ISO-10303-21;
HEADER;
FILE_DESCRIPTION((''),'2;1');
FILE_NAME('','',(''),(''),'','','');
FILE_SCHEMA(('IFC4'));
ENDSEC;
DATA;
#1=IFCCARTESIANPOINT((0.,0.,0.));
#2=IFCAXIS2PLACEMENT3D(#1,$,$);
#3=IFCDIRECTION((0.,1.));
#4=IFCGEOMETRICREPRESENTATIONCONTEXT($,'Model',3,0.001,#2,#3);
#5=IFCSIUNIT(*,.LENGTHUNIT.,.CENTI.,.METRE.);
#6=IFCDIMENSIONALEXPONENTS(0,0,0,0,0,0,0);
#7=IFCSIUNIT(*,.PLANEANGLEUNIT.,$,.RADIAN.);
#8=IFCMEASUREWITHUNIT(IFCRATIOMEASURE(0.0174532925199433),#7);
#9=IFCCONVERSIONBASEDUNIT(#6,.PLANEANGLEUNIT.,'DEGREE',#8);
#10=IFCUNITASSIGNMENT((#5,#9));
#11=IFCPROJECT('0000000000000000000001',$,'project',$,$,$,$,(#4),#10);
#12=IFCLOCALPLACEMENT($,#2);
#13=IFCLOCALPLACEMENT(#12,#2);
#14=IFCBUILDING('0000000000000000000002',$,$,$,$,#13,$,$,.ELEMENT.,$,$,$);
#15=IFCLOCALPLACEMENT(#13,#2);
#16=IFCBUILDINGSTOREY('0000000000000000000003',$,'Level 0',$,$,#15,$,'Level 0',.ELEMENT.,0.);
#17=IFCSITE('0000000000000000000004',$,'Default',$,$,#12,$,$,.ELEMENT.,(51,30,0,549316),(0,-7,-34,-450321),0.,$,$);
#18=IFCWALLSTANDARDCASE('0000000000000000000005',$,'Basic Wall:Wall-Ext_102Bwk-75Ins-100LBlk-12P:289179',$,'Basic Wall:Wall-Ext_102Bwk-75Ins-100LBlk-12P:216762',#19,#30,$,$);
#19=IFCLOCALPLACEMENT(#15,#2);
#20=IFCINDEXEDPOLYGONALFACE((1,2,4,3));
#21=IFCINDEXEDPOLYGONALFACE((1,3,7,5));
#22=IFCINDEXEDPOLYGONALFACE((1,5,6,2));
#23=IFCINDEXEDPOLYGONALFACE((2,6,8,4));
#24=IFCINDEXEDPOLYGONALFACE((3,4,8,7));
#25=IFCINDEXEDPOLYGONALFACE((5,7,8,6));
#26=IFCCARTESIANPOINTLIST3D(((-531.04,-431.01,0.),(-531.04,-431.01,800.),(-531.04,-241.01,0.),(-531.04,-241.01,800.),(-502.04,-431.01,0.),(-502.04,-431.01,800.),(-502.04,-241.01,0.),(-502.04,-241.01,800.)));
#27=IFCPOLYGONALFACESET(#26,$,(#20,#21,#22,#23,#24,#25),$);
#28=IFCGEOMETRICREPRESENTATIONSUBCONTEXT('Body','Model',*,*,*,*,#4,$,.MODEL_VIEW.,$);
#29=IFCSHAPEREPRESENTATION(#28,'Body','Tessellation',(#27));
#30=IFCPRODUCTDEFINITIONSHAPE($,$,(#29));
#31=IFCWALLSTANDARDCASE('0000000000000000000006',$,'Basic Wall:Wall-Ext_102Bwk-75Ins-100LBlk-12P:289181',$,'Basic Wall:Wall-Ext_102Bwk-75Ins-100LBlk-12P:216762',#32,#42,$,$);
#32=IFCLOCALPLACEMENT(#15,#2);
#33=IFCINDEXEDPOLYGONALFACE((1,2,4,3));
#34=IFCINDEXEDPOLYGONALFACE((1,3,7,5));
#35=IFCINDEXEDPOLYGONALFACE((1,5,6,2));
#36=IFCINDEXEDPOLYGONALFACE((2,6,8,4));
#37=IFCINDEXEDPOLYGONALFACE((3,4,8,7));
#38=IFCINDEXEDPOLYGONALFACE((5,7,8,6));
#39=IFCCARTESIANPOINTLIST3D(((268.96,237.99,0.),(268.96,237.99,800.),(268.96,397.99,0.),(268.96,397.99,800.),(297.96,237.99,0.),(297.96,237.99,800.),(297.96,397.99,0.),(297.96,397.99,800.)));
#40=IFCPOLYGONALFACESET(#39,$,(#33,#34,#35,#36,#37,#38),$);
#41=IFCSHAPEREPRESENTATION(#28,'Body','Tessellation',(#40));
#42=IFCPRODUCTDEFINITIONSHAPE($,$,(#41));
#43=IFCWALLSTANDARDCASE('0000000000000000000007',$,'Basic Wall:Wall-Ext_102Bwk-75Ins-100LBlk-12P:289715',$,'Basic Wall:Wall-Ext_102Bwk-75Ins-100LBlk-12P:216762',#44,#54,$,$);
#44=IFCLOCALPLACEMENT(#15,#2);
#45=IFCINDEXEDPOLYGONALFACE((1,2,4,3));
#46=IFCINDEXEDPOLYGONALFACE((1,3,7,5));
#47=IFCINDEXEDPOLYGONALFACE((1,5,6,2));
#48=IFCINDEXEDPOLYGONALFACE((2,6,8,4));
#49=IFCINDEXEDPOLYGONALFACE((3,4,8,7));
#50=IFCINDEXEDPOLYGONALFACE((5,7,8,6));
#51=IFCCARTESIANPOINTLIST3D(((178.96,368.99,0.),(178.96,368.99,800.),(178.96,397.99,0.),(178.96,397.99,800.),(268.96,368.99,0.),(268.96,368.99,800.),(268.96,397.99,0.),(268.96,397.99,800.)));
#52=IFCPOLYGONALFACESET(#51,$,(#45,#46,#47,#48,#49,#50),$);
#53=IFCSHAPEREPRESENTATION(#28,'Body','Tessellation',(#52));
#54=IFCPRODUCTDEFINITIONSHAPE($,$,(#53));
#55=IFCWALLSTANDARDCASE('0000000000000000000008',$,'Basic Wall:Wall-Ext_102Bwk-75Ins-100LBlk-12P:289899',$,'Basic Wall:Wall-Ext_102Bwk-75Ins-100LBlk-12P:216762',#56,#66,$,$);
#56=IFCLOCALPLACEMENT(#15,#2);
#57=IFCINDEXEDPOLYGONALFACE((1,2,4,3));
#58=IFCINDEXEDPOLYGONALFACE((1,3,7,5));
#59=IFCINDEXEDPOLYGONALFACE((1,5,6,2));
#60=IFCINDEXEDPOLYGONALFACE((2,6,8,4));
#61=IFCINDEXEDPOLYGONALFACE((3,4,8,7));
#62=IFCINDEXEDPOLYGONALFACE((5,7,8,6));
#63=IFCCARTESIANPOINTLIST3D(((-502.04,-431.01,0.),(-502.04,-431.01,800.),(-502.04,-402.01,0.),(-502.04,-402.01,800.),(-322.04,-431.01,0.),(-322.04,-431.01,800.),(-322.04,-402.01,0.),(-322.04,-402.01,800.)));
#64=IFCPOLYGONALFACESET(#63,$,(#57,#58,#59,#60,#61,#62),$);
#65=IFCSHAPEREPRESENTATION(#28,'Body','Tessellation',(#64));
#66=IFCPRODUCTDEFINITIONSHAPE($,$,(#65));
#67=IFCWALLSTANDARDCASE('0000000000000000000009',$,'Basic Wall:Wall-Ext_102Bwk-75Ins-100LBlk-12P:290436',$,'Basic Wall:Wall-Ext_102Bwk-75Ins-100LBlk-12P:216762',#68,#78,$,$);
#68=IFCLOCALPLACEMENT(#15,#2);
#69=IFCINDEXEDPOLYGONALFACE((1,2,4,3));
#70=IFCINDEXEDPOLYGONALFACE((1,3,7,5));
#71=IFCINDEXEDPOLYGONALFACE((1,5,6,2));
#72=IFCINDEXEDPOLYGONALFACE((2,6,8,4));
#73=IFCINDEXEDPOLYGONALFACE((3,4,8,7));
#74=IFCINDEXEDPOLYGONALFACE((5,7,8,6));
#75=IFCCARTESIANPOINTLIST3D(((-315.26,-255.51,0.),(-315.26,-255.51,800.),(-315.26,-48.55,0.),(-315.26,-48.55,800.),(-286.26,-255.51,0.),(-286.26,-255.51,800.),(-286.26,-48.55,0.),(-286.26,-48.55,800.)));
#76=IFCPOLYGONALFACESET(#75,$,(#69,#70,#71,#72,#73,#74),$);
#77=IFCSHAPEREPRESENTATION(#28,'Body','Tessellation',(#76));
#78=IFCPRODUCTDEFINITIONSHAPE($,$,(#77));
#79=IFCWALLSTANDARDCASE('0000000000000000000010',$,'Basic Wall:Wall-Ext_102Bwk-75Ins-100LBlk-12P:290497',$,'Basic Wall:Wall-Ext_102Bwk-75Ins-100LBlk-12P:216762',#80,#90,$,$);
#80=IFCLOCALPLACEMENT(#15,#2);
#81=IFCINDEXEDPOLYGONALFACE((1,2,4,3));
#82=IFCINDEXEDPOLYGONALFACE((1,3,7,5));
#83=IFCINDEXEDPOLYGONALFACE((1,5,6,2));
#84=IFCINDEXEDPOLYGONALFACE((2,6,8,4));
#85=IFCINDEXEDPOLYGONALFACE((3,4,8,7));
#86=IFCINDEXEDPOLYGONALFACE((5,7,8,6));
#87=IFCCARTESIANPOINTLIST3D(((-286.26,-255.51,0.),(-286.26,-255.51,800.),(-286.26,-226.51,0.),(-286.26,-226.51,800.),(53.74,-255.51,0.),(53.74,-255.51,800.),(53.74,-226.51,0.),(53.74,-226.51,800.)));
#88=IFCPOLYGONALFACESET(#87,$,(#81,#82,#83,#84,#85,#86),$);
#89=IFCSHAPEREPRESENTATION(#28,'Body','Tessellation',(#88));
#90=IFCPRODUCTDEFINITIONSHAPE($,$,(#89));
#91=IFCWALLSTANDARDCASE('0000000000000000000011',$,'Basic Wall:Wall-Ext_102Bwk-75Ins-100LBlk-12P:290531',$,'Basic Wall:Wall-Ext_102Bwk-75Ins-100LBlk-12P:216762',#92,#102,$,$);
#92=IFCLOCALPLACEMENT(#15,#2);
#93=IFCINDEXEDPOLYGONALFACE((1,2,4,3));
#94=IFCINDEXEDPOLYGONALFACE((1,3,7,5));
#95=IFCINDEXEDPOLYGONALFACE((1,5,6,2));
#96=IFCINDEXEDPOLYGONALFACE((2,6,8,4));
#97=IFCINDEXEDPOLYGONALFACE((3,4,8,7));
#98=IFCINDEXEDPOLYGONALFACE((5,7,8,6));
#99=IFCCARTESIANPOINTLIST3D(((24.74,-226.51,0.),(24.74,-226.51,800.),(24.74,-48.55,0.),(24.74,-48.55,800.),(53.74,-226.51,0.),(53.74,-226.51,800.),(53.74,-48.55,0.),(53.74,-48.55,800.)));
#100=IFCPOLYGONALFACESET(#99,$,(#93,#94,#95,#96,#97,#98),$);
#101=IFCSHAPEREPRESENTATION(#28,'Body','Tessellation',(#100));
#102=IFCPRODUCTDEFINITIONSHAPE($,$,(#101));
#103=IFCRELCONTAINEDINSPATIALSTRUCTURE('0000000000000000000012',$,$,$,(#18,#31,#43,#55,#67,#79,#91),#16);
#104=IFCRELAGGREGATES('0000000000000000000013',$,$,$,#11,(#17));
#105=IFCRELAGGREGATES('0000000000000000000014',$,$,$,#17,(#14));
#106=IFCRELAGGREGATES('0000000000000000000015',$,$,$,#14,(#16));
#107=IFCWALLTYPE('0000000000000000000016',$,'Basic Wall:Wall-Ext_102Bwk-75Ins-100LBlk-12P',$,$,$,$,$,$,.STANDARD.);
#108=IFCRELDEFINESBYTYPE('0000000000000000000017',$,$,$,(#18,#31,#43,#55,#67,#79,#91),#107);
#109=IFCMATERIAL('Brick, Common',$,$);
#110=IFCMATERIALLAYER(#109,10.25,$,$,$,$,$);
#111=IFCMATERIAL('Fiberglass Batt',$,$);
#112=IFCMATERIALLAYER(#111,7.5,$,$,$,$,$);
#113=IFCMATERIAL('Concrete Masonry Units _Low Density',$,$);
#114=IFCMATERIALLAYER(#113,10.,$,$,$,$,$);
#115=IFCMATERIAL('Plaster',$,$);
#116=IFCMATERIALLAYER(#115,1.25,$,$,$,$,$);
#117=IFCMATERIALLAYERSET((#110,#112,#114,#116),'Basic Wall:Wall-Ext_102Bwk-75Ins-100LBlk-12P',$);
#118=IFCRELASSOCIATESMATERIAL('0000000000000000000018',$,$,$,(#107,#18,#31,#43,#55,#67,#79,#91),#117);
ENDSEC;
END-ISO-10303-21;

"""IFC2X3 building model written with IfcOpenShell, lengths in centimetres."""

from ifc_helpers import new_model, entity, si_unit, converted_unit, direction, frame, frame_2d, origin, place, context, subcontext, project, spatial, rectangle, extrude, material, layer, layer_set, layer_usage, type_object, element, save


model = new_model("IFC2X3")

# Units and contexts
model_context = context("Model", 3, precision=0.001, world=origin(), true_north=direction((0.0, 1.0)))
body_context = subcontext(model_context, "Body", "Model", "MODEL_VIEW")
ifc_project = project(units=[si_unit("LENGTHUNIT", "METRE", prefix="CENTI"), converted_unit("PLANEANGLEUNIT", "DEGREE", entity("IfcRatioMeasure", 0.0174532925199433), si_unit("PLANEANGLEUNIT", "RADIAN"), dimensions=[0, 0, 0, 0, 0, 0, 0])], contexts=[model_context])

# Site, building, storey
site_placement = place(None, origin())
site = spatial("IfcSite", under=ifc_project, at=site_placement, Name="Default", CompositionType="ELEMENT", RefLatitude=(51, 30, 0, 549316), RefLongitude=(0, -7, -34, -450321), RefElevation=0.0)
building_placement = place(site_placement, origin())
building = spatial("IfcBuilding", under=site, at=building_placement, CompositionType="ELEMENT")
storey_placement = place(building_placement, origin())
storey = spatial("IfcBuildingStorey", under=building, at=storey_placement, Name="Level 0", LongName="Level 0", CompositionType="ELEMENT", Elevation=0.0)

# Walls
ifc_material_1 = material(Name="Brick, Common")
ifc_layer_1 = layer(ifc_material_1, 10.25)
ifc_material_2 = material(Name="Fiberglass Batt")
ifc_layer_2 = layer(ifc_material_2, 7.5)
ifc_material_3 = material(Name="Concrete Masonry Units _Low Density")
ifc_layer_3 = layer(ifc_material_3, 10.0)
ifc_material_4 = material(Name="Plaster")
ifc_layer_4 = layer(ifc_material_4, 1.25)
ifc_layer_set = layer_set([ifc_layer_1, ifc_layer_2, ifc_layer_3, ifc_layer_4], Name="Basic Wall:Wall-Ext_102Bwk-75Ins-100LBlk-12P")
ifc_layer_usage_1 = layer_usage(ifc_layer_set, "AXIS2", "NEGATIVE", 14.5)
wall_type = type_object("IfcWallType", Name="Basic Wall:Wall-Ext_102Bwk-75Ins-100LBlk-12P", PredefinedType="STANDARD", material=ifc_layer_set)
wall_1_placement = place(storey_placement, frame((-516.54, -431.01, 0.0), z_axis=(0.0, 0.0, 1.0), x_axis=(0.0, 1.0, 0.0)))
element("IfcWallStandardCase", 1, at=wall_1_placement, inside=storey, type_object=wall_type, material=ifc_layer_usage_1, Name="Basic Wall:Wall-Ext_102Bwk-75Ins-100LBlk-12P:289179", ObjectType="Basic Wall:Wall-Ext_102Bwk-75Ins-100LBlk-12P:216762", context=body_context, shape_type="SweptSolid", body=[
    extrude(rectangle(XDim=190.0, YDim=29.0, at=frame_2d((95.0, 0.0), x_axis=(-1.0, 0.0))), origin(), (0.0, 0.0, 1.0), 800.0),
])
ifc_layer_usage_2 = layer_usage(ifc_layer_set, "AXIS2", "NEGATIVE", 14.5)
wall_2_placement = place(storey_placement, frame((283.46, 397.99, 0.0), z_axis=(0.0, 0.0, 1.0), x_axis=(0.0, -1.0, 0.0)))
element("IfcWallStandardCase", 2, at=wall_2_placement, inside=storey, type_object=wall_type, material=ifc_layer_usage_2, Name="Basic Wall:Wall-Ext_102Bwk-75Ins-100LBlk-12P:289181", ObjectType="Basic Wall:Wall-Ext_102Bwk-75Ins-100LBlk-12P:216762", context=body_context, shape_type="SweptSolid", body=[
    extrude(rectangle(XDim=160.0, YDim=29.0, at=frame_2d((80.0, 0.0), x_axis=(-1.0, 0.0))), origin(), (0.0, 0.0, 1.0), 800.0),
])
ifc_layer_usage_3 = layer_usage(ifc_layer_set, "AXIS2", "NEGATIVE", 14.5)
wall_3_placement = place(storey_placement, frame((178.96, 383.49, 0.0)))
element("IfcWallStandardCase", 3, at=wall_3_placement, inside=storey, type_object=wall_type, material=ifc_layer_usage_3, Name="Basic Wall:Wall-Ext_102Bwk-75Ins-100LBlk-12P:289715", ObjectType="Basic Wall:Wall-Ext_102Bwk-75Ins-100LBlk-12P:216762", context=body_context, shape_type="SweptSolid", body=[
    extrude(rectangle(XDim=90.0, YDim=29.0, at=frame_2d((45.0, 0.0), x_axis=(-1.0, 0.0))), origin(), (0.0, 0.0, 1.0), 800.0),
])
ifc_layer_usage_4 = layer_usage(ifc_layer_set, "AXIS2", "NEGATIVE", 14.5)
wall_4_placement = place(storey_placement, frame((-322.04, -416.51, 0.0), z_axis=(0.0, 0.0, 1.0), x_axis=(-1.0, 0.0, 0.0)))
element("IfcWallStandardCase", 4, at=wall_4_placement, inside=storey, type_object=wall_type, material=ifc_layer_usage_4, Name="Basic Wall:Wall-Ext_102Bwk-75Ins-100LBlk-12P:289899", ObjectType="Basic Wall:Wall-Ext_102Bwk-75Ins-100LBlk-12P:216762", context=body_context, shape_type="SweptSolid", body=[
    extrude(rectangle(XDim=180.0, YDim=29.0, at=frame_2d((90.0, 0.0), x_axis=(-1.0, 0.0))), origin(), (0.0, 0.0, 1.0), 800.0),
])
ifc_layer_usage_5 = layer_usage(ifc_layer_set, "AXIS2", "NEGATIVE", 14.5)
wall_5_placement = place(storey_placement, frame((-300.76, -48.55, 0.0), z_axis=(0.0, 0.0, 1.0), x_axis=(0.0, -1.0, 0.0)))
element("IfcWallStandardCase", 5, at=wall_5_placement, inside=storey, type_object=wall_type, material=ifc_layer_usage_5, Name="Basic Wall:Wall-Ext_102Bwk-75Ins-100LBlk-12P:290436", ObjectType="Basic Wall:Wall-Ext_102Bwk-75Ins-100LBlk-12P:216762", context=body_context, shape_type="SweptSolid", body=[
    extrude(rectangle(XDim=206.96, YDim=29.0, at=frame_2d((103.48, 0.0), x_axis=(-1.0, 0.0))), origin(), (0.0, 0.0, 1.0), 800.0),
])
ifc_layer_usage_6 = layer_usage(ifc_layer_set, "AXIS2", "NEGATIVE", 14.5)
wall_6_placement = place(storey_placement, frame((-286.26, -241.01, 0.0)))
element("IfcWallStandardCase", 6, at=wall_6_placement, inside=storey, type_object=wall_type, material=ifc_layer_usage_6, Name="Basic Wall:Wall-Ext_102Bwk-75Ins-100LBlk-12P:290497", ObjectType="Basic Wall:Wall-Ext_102Bwk-75Ins-100LBlk-12P:216762", context=body_context, shape_type="SweptSolid", body=[
    extrude(rectangle(XDim=340.0, YDim=29.0, at=frame_2d((170.0, 0.0), x_axis=(-1.0, 0.0))), origin(), (0.0, 0.0, 1.0), 800.0),
])
ifc_layer_usage_7 = layer_usage(ifc_layer_set, "AXIS2", "NEGATIVE", 14.5)
wall_7_placement = place(storey_placement, frame((39.24, -226.51, 0.0), z_axis=(0.0, 0.0, 1.0), x_axis=(0.0, 1.0, 0.0)))
element("IfcWallStandardCase", 7, at=wall_7_placement, inside=storey, type_object=wall_type, material=ifc_layer_usage_7, Name="Basic Wall:Wall-Ext_102Bwk-75Ins-100LBlk-12P:290531", ObjectType="Basic Wall:Wall-Ext_102Bwk-75Ins-100LBlk-12P:216762", context=body_context, shape_type="SweptSolid", body=[
    extrude(rectangle(XDim=177.96, YDim=29.0, at=frame_2d((88.98, 0.0), x_axis=(-1.0, 0.0))), origin(), (0.0, 0.0, 1.0), 800.0),
])

save(model, "model.ifc")
